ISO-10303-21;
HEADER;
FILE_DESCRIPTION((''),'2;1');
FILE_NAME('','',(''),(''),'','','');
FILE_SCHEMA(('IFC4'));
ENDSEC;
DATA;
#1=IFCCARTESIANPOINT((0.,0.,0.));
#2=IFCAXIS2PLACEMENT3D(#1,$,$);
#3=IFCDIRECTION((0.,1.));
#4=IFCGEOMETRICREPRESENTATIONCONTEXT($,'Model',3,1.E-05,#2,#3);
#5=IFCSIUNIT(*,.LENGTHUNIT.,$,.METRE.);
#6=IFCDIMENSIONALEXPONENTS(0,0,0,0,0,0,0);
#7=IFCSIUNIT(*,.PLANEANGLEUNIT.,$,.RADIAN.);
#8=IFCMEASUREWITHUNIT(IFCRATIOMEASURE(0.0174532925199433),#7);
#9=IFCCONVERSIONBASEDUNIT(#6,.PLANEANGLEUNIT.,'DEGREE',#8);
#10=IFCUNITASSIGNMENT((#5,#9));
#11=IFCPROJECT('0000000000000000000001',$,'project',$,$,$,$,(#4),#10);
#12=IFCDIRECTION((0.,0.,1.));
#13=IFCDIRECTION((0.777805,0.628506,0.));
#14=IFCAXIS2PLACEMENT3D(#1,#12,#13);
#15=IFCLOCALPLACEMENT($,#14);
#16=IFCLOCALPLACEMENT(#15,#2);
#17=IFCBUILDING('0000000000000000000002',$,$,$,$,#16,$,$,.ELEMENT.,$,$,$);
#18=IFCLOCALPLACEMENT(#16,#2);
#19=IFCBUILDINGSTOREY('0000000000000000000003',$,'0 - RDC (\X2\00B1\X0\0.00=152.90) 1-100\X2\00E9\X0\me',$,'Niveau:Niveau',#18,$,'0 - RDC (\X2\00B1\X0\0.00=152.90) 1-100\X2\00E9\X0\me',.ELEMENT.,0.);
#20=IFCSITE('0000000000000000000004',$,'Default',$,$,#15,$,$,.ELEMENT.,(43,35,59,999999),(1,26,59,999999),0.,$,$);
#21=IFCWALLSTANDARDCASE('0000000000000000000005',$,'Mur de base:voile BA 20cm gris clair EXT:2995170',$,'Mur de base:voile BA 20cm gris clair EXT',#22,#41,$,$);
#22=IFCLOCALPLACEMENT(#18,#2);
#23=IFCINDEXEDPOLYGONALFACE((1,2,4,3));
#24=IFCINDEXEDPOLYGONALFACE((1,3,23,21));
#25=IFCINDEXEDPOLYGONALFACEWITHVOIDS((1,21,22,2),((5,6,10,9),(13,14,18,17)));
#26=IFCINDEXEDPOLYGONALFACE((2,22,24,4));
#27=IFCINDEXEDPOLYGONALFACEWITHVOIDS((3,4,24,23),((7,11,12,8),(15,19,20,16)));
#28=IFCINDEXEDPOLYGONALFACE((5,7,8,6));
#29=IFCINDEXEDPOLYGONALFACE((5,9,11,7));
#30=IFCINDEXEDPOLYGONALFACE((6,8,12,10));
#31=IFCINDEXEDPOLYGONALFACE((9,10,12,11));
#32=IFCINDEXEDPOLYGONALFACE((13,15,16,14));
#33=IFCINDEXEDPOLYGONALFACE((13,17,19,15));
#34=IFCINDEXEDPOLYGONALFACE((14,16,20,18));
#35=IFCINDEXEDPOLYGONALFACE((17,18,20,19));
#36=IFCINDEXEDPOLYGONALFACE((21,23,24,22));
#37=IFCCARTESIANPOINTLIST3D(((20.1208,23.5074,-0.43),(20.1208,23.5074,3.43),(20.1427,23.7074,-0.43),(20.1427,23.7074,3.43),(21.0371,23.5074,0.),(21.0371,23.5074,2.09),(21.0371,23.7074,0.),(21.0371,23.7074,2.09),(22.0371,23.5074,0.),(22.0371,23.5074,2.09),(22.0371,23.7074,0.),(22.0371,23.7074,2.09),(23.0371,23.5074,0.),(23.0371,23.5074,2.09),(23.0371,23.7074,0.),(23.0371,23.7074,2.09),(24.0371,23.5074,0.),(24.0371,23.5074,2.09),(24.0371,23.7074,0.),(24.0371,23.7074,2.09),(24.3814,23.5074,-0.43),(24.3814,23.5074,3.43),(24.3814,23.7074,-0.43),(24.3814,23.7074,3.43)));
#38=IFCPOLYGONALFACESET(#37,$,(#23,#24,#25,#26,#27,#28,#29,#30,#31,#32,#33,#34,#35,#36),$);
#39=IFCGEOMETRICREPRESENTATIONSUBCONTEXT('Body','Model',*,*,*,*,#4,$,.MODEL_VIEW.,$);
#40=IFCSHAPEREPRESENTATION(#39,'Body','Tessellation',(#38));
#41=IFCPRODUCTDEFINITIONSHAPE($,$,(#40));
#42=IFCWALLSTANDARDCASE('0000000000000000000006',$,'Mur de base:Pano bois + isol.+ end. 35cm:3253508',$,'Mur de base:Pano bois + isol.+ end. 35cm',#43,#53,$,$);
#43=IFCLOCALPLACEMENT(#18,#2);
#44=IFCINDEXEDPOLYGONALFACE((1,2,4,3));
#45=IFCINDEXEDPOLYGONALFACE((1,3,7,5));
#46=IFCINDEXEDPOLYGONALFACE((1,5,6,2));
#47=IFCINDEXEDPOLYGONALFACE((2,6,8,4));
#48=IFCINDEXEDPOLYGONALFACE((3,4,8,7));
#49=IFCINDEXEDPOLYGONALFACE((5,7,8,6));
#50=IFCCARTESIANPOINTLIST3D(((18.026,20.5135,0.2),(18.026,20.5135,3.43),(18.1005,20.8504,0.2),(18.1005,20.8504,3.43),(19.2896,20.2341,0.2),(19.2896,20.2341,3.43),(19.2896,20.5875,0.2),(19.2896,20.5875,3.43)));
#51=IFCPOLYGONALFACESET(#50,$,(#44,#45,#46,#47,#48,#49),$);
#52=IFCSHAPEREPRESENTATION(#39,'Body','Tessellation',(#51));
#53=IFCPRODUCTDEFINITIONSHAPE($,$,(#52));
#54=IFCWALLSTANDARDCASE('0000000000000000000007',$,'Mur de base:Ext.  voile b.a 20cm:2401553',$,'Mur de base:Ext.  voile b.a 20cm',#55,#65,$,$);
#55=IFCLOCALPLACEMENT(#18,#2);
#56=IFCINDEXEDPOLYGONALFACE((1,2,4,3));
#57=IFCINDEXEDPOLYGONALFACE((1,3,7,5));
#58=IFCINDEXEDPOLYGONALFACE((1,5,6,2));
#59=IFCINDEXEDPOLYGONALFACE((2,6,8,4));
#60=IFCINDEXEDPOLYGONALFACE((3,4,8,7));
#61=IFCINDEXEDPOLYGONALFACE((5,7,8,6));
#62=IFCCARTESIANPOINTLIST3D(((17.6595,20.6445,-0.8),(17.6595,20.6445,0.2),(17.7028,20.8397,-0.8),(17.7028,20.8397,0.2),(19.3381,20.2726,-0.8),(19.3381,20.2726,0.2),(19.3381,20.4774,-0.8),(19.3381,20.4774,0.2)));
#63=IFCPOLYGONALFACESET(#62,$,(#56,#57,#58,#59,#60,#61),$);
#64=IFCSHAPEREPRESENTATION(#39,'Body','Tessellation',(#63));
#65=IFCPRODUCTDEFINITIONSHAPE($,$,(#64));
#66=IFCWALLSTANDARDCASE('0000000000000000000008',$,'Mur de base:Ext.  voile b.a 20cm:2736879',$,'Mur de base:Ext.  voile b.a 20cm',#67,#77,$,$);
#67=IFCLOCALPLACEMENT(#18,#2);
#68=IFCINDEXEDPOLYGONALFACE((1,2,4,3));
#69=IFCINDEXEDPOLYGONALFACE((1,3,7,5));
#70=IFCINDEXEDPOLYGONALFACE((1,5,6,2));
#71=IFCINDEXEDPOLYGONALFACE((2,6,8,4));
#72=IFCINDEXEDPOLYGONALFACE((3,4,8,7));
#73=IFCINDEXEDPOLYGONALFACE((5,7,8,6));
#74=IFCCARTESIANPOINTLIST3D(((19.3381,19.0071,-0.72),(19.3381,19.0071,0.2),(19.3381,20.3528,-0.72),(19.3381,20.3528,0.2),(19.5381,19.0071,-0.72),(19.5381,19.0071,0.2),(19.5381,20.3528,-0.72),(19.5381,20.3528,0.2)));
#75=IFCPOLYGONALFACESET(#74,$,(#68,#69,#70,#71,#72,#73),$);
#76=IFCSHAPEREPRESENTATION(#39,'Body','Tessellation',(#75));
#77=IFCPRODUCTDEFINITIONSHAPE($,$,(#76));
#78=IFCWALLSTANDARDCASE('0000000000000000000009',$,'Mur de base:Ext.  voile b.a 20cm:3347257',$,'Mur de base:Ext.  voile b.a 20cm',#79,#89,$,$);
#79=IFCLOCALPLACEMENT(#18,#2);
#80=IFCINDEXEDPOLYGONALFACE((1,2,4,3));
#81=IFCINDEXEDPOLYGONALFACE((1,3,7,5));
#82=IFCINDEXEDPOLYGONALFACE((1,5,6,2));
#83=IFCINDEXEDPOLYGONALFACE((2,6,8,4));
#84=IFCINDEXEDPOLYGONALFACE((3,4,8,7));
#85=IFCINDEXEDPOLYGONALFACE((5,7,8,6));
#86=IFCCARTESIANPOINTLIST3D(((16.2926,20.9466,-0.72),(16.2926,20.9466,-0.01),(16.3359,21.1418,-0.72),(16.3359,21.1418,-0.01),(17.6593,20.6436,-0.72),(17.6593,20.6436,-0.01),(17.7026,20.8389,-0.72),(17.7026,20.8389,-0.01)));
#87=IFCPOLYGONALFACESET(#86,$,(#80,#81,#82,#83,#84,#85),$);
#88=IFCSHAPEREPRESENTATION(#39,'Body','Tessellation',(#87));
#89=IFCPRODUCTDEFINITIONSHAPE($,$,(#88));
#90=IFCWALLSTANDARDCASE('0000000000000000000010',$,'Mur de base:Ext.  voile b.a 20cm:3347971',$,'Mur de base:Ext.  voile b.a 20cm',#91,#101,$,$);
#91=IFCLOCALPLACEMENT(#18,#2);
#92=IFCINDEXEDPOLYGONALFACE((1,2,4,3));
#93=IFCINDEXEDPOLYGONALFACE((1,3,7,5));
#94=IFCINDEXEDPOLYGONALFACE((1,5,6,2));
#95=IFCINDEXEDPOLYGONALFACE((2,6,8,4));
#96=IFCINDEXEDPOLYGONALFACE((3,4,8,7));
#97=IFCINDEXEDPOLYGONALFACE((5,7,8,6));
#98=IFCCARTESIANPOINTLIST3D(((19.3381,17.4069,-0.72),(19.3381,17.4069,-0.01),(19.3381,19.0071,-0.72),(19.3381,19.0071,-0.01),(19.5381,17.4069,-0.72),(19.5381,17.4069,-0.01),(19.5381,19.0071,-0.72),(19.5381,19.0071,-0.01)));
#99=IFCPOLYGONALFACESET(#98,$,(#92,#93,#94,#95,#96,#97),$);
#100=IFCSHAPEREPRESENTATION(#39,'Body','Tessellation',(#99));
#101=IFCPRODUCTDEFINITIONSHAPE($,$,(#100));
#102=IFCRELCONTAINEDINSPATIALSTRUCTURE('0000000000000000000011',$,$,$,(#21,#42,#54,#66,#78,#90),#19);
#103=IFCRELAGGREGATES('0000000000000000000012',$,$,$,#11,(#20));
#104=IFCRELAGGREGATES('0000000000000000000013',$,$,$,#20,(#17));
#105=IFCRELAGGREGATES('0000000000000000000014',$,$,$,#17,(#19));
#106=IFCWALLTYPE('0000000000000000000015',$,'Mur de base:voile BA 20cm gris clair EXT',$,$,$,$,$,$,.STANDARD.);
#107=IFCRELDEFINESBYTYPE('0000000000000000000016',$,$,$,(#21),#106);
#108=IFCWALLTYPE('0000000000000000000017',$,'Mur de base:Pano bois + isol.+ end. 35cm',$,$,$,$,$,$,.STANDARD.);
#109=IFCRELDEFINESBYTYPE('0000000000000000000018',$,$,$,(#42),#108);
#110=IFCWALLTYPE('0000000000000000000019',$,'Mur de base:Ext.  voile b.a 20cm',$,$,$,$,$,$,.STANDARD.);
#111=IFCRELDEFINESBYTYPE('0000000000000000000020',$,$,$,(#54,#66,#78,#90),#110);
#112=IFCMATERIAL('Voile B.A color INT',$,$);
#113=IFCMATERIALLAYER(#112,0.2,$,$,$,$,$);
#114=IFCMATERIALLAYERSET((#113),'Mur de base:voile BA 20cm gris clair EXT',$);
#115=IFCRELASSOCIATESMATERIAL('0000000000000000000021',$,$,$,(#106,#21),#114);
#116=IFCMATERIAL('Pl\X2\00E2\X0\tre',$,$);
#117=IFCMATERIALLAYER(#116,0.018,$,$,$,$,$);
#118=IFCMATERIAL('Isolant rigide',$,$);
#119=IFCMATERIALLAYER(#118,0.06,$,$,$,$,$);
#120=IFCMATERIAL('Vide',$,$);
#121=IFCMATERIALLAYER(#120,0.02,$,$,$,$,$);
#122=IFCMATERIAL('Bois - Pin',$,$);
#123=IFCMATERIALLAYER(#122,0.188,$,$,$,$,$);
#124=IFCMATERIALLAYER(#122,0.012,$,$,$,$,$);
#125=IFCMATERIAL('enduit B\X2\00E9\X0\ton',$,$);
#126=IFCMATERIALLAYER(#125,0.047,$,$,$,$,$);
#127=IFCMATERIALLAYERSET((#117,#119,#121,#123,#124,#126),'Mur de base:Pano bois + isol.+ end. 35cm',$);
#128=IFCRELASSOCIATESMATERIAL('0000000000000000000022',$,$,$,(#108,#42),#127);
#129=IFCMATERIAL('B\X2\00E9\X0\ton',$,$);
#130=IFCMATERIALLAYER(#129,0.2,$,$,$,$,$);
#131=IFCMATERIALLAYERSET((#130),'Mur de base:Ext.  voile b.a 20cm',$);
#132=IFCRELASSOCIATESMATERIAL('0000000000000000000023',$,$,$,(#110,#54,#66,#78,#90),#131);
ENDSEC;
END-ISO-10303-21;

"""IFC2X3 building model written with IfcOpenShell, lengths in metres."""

from ifc_helpers import new_model, entity, si_unit, converted_unit, direction, frame, frame_2d, origin, place, context, subcontext, project, spatial, polyline, rectangle, outline, extrude, clip, bounded_halfspace, material, layer, layer_set, layer_usage, type_object, element, save


model = new_model("IFC2X3")

# Units and contexts
model_context = context("Model", 3, precision=1e-05, world=origin(), true_north=direction((0.0, 1.0)))
body_context = subcontext(model_context, "Body", "Model", "MODEL_VIEW")
ifc_project = project(units=[si_unit("LENGTHUNIT", "METRE"), converted_unit("PLANEANGLEUNIT", "DEGREE", entity("IfcRatioMeasure", 0.0174532925199433), si_unit("PLANEANGLEUNIT", "RADIAN"), dimensions=[0, 0, 0, 0, 0, 0, 0])], contexts=[model_context])

# Site, building, storey
site_placement = place(None, frame((0.0, 0.0, 0.0), z_axis=(0.0, 0.0, 1.0), x_axis=(0.777805, 0.628506, 0.0)))
site = spatial("IfcSite", under=ifc_project, at=site_placement, Name="Default", CompositionType="ELEMENT", RefLatitude=(43, 35, 59, 999999), RefLongitude=(1, 26, 59, 999999), RefElevation=0.0)
building_placement = place(site_placement, origin())
building = spatial("IfcBuilding", under=site, at=building_placement, CompositionType="ELEMENT")
storey_placement = place(building_placement, origin())
storey = spatial("IfcBuildingStorey", under=building, at=storey_placement, Name="0 - RDC (±0.00=152.90) 1-100éme", ObjectType="Niveau:Niveau", LongName="0 - RDC (±0.00=152.90) 1-100éme", CompositionType="ELEMENT", Elevation=0.0)

# Shared definitions
ifc_material_1 = material(Name="Voile B.A color INT")
ifc_layer_1 = layer(ifc_material_1, 0.2)
ifc_layer_set_1 = layer_set([ifc_layer_1], Name="Mur de base:voile BA 20cm gris clair EXT")
wall_type_1 = type_object("IfcWallType", Name="Mur de base:voile BA 20cm gris clair EXT", PredefinedType="STANDARD", material=ifc_layer_set_1)

# Wall, openings
ifc_layer_usage_1 = layer_usage(ifc_layer_set_1, "AXIS2", "NEGATIVE", 0.1)
wall_1_placement = place(storey_placement, frame((20.1208, 23.6074, -0.43)))
wall_1 = element("IfcWallStandardCase", 1, at=wall_1_placement, inside=storey, type_object=wall_type_1, material=ifc_layer_usage_1, Name="Mur de base:voile BA 20cm gris clair EXT:2995170", ObjectType="Mur de base:voile BA 20cm gris clair EXT", context=body_context, shape_type="SweptSolid", body=[
    extrude(outline(polyline([(4.2606, -0.1), (4.2606, 0.1), (0.0218, 0.1), (0.0, -0.1), (4.2606, -0.1)])), origin(), (0.0, 0.0, 1.0), 3.86),
])
opening_1_placement = place(wall_1_placement, frame((0.9163, -0.1, 0.43)))
element("IfcOpeningElement", 2, at=opening_1_placement, cuts=wall_1, ObjectType="Opening", context=body_context, shape_type="SweptSolid", body=[
    extrude(rectangle(XDim=2.09, YDim=1.0, at=frame_2d((1.045, 0.5), x_axis=(1.0, 0.0))), frame((0.0, 0.0, 0.0), z_axis=(0.0, 1.0, 0.0), x_axis=(0.0, 0.0, 1.0)), (0.0, 0.0, 1.0), 0.2),
])
opening_2_placement = place(wall_1_placement, frame((3.9163, 0.1, 0.43)))
element("IfcOpeningElement", 3, at=opening_2_placement, cuts=wall_1, ObjectType="Opening", context=body_context, shape_type="SweptSolid", body=[
    extrude(rectangle(XDim=2.09, YDim=1.0, at=frame_2d((1.045, 0.5), x_axis=(1.0, 0.0))), frame((0.0, 0.0, 0.0), z_axis=(0.0, -1.0, 0.0), x_axis=(0.0, 0.0, 1.0)), (0.0, 0.0, 1.0), 0.2),
])

# Walls
ifc_material_2 = material(Name="Plâtre")
ifc_layer_2 = layer(ifc_material_2, 0.018)
ifc_material_3 = material(Name="Isolant rigide")
ifc_layer_3 = layer(ifc_material_3, 0.06)
ifc_material_4 = material(Name="Vide")
ifc_layer_4 = layer(ifc_material_4, 0.02)
ifc_material_5 = material(Name="Bois - Pin")
ifc_layer_5 = layer(ifc_material_5, 0.188)
ifc_layer_6 = layer(ifc_material_5, 0.012)
ifc_material_6 = material(Name="enduit Béton")
ifc_layer_7 = layer(ifc_material_6, 0.047)
ifc_layer_set_2 = layer_set([ifc_layer_2, ifc_layer_3, ifc_layer_4, ifc_layer_5, ifc_layer_6, ifc_layer_7], Name="Mur de base:Pano bois + isol.+ end. 35cm")
ifc_layer_usage_2 = layer_usage(ifc_layer_set_2, "AXIS2", "NEGATIVE", 0.1725)
wall_type_2 = type_object("IfcWallType", Name="Mur de base:Pano bois + isol.+ end. 35cm", PredefinedType="STANDARD", material=ifc_layer_set_2)
wall_2_placement = place(storey_placement, frame((18.0632, 20.682, 0.2), z_axis=(0.0, 0.0, 1.0), x_axis=(0.976415, -0.2159, 0.0)))
element("IfcWallStandardCase", 4, at=wall_2_placement, inside=storey, type_object=wall_type_2, material=ifc_layer_usage_2, Name="Mur de base:Pano bois + isol.+ end. 35cm:3253508", ObjectType="Mur de base:Pano bois + isol.+ end. 35cm", context=body_context, shape_type="Clipping", body=[
    clip(extrude(outline(polyline([(1.2942, -0.1725), (1.2179, 0.1725), (0.0, 0.1725), (0.0, -0.1725), (1.2942, -0.1725)])), origin(), (0.0, 0.0, 1.0), 3.23), bounded_halfspace(frame((0.2148, -0.1725, 3.23), z_axis=(0.0, 0.0, -1.0), x_axis=(0.2159, -0.976415, 0.0)), True, frame((0.2148, -0.1725, 3.23)), polyline([(0.0, 0.0), (1.0793, 0.0), (1.0031, 0.345), (-0.0763, 0.345), (0.0, 0.0)]))),
])
ifc_material_7 = material(Name="Béton")
ifc_layer_8 = layer(ifc_material_7, 0.2)
ifc_layer_set_3 = layer_set([ifc_layer_8], Name="Mur de base:Ext.  voile b.a 20cm")
ifc_layer_usage_3 = layer_usage(ifc_layer_set_3, "AXIS2", "NEGATIVE", 0.1)
wall_type_3 = type_object("IfcWallType", Name="Mur de base:Ext.  voile b.a 20cm", PredefinedType="STANDARD", material=ifc_layer_set_3)
wall_3_placement = place(storey_placement, frame((19.3598, 20.3702, -0.8), z_axis=(0.0, 0.0, 1.0), x_axis=(-0.976324, 0.216313, 0.0)))
element("IfcWallStandardCase", 5, at=wall_3_placement, inside=storey, type_object=wall_type_3, material=ifc_layer_usage_3, Name="Mur de base:Ext.  voile b.a 20cm:2401553", ObjectType="Mur de base:Ext.  voile b.a 20cm", context=body_context, shape_type="SweptSolid", body=[
    extrude(outline(polyline([(1.7193, -0.1), (1.7193, 0.1), (0.0, 0.1), (0.0443, -0.1), (1.7193, -0.1)])), origin(), (0.0, 0.0, 1.0), 1.0),
])
ifc_layer_usage_4 = layer_usage(ifc_layer_set_3, "AXIS2", "NEGATIVE", 0.1)
wall_4_placement = place(storey_placement, frame((19.4381, 20.3528, -0.72), z_axis=(0.0, 0.0, 1.0), x_axis=(0.0, -1.0, 0.0)))
element("IfcWallStandardCase", 6, at=wall_4_placement, inside=storey, type_object=wall_type_3, material=ifc_layer_usage_4, Name="Mur de base:Ext.  voile b.a 20cm:2736879", ObjectType="Mur de base:Ext.  voile b.a 20cm", context=body_context, shape_type="SweptSolid", body=[
    extrude(rectangle(XDim=1.3457, YDim=0.2, at=frame_2d((0.6729, 0.0), x_axis=(-1.0, 0.0))), origin(), (0.0, 0.0, 1.0), 0.92),
])
ifc_layer_usage_5 = layer_usage(ifc_layer_set_3, "AXIS2", "NEGATIVE", 0.1)
wall_5_placement = place(storey_placement, frame((17.6809, 20.7413, -0.72), z_axis=(0.0, 0.0, 1.0), x_axis=(-0.976304, 0.216405, 0.0)))
element("IfcWallStandardCase", 7, at=wall_5_placement, inside=storey, type_object=wall_type_3, material=ifc_layer_usage_5, Name="Mur de base:Ext.  voile b.a 20cm:3347257", ObjectType="Mur de base:Ext.  voile b.a 20cm", context=body_context, shape_type="SweptSolid", body=[
    extrude(rectangle(XDim=1.3999, YDim=0.2, at=frame_2d((0.6999, 0.0), x_axis=(-1.0, 0.0))), origin(), (0.0, 0.0, 1.0), 0.71),
])
ifc_layer_usage_6 = layer_usage(ifc_layer_set_3, "AXIS2", "NEGATIVE", 0.1)
wall_6_placement = place(storey_placement, frame((19.4381, 19.0071, -0.72), z_axis=(0.0, 0.0, 1.0), x_axis=(0.0, -1.0, 0.0)))
element("IfcWallStandardCase", 8, at=wall_6_placement, inside=storey, type_object=wall_type_3, material=ifc_layer_usage_6, Name="Mur de base:Ext.  voile b.a 20cm:3347971", ObjectType="Mur de base:Ext.  voile b.a 20cm", context=body_context, shape_type="SweptSolid", body=[
    extrude(rectangle(XDim=1.6002, YDim=0.2, at=frame_2d((0.8001, 0.0), x_axis=(-1.0, 0.0))), origin(), (0.0, 0.0, 1.0), 0.71),
])

save(model, "model.ifc")
